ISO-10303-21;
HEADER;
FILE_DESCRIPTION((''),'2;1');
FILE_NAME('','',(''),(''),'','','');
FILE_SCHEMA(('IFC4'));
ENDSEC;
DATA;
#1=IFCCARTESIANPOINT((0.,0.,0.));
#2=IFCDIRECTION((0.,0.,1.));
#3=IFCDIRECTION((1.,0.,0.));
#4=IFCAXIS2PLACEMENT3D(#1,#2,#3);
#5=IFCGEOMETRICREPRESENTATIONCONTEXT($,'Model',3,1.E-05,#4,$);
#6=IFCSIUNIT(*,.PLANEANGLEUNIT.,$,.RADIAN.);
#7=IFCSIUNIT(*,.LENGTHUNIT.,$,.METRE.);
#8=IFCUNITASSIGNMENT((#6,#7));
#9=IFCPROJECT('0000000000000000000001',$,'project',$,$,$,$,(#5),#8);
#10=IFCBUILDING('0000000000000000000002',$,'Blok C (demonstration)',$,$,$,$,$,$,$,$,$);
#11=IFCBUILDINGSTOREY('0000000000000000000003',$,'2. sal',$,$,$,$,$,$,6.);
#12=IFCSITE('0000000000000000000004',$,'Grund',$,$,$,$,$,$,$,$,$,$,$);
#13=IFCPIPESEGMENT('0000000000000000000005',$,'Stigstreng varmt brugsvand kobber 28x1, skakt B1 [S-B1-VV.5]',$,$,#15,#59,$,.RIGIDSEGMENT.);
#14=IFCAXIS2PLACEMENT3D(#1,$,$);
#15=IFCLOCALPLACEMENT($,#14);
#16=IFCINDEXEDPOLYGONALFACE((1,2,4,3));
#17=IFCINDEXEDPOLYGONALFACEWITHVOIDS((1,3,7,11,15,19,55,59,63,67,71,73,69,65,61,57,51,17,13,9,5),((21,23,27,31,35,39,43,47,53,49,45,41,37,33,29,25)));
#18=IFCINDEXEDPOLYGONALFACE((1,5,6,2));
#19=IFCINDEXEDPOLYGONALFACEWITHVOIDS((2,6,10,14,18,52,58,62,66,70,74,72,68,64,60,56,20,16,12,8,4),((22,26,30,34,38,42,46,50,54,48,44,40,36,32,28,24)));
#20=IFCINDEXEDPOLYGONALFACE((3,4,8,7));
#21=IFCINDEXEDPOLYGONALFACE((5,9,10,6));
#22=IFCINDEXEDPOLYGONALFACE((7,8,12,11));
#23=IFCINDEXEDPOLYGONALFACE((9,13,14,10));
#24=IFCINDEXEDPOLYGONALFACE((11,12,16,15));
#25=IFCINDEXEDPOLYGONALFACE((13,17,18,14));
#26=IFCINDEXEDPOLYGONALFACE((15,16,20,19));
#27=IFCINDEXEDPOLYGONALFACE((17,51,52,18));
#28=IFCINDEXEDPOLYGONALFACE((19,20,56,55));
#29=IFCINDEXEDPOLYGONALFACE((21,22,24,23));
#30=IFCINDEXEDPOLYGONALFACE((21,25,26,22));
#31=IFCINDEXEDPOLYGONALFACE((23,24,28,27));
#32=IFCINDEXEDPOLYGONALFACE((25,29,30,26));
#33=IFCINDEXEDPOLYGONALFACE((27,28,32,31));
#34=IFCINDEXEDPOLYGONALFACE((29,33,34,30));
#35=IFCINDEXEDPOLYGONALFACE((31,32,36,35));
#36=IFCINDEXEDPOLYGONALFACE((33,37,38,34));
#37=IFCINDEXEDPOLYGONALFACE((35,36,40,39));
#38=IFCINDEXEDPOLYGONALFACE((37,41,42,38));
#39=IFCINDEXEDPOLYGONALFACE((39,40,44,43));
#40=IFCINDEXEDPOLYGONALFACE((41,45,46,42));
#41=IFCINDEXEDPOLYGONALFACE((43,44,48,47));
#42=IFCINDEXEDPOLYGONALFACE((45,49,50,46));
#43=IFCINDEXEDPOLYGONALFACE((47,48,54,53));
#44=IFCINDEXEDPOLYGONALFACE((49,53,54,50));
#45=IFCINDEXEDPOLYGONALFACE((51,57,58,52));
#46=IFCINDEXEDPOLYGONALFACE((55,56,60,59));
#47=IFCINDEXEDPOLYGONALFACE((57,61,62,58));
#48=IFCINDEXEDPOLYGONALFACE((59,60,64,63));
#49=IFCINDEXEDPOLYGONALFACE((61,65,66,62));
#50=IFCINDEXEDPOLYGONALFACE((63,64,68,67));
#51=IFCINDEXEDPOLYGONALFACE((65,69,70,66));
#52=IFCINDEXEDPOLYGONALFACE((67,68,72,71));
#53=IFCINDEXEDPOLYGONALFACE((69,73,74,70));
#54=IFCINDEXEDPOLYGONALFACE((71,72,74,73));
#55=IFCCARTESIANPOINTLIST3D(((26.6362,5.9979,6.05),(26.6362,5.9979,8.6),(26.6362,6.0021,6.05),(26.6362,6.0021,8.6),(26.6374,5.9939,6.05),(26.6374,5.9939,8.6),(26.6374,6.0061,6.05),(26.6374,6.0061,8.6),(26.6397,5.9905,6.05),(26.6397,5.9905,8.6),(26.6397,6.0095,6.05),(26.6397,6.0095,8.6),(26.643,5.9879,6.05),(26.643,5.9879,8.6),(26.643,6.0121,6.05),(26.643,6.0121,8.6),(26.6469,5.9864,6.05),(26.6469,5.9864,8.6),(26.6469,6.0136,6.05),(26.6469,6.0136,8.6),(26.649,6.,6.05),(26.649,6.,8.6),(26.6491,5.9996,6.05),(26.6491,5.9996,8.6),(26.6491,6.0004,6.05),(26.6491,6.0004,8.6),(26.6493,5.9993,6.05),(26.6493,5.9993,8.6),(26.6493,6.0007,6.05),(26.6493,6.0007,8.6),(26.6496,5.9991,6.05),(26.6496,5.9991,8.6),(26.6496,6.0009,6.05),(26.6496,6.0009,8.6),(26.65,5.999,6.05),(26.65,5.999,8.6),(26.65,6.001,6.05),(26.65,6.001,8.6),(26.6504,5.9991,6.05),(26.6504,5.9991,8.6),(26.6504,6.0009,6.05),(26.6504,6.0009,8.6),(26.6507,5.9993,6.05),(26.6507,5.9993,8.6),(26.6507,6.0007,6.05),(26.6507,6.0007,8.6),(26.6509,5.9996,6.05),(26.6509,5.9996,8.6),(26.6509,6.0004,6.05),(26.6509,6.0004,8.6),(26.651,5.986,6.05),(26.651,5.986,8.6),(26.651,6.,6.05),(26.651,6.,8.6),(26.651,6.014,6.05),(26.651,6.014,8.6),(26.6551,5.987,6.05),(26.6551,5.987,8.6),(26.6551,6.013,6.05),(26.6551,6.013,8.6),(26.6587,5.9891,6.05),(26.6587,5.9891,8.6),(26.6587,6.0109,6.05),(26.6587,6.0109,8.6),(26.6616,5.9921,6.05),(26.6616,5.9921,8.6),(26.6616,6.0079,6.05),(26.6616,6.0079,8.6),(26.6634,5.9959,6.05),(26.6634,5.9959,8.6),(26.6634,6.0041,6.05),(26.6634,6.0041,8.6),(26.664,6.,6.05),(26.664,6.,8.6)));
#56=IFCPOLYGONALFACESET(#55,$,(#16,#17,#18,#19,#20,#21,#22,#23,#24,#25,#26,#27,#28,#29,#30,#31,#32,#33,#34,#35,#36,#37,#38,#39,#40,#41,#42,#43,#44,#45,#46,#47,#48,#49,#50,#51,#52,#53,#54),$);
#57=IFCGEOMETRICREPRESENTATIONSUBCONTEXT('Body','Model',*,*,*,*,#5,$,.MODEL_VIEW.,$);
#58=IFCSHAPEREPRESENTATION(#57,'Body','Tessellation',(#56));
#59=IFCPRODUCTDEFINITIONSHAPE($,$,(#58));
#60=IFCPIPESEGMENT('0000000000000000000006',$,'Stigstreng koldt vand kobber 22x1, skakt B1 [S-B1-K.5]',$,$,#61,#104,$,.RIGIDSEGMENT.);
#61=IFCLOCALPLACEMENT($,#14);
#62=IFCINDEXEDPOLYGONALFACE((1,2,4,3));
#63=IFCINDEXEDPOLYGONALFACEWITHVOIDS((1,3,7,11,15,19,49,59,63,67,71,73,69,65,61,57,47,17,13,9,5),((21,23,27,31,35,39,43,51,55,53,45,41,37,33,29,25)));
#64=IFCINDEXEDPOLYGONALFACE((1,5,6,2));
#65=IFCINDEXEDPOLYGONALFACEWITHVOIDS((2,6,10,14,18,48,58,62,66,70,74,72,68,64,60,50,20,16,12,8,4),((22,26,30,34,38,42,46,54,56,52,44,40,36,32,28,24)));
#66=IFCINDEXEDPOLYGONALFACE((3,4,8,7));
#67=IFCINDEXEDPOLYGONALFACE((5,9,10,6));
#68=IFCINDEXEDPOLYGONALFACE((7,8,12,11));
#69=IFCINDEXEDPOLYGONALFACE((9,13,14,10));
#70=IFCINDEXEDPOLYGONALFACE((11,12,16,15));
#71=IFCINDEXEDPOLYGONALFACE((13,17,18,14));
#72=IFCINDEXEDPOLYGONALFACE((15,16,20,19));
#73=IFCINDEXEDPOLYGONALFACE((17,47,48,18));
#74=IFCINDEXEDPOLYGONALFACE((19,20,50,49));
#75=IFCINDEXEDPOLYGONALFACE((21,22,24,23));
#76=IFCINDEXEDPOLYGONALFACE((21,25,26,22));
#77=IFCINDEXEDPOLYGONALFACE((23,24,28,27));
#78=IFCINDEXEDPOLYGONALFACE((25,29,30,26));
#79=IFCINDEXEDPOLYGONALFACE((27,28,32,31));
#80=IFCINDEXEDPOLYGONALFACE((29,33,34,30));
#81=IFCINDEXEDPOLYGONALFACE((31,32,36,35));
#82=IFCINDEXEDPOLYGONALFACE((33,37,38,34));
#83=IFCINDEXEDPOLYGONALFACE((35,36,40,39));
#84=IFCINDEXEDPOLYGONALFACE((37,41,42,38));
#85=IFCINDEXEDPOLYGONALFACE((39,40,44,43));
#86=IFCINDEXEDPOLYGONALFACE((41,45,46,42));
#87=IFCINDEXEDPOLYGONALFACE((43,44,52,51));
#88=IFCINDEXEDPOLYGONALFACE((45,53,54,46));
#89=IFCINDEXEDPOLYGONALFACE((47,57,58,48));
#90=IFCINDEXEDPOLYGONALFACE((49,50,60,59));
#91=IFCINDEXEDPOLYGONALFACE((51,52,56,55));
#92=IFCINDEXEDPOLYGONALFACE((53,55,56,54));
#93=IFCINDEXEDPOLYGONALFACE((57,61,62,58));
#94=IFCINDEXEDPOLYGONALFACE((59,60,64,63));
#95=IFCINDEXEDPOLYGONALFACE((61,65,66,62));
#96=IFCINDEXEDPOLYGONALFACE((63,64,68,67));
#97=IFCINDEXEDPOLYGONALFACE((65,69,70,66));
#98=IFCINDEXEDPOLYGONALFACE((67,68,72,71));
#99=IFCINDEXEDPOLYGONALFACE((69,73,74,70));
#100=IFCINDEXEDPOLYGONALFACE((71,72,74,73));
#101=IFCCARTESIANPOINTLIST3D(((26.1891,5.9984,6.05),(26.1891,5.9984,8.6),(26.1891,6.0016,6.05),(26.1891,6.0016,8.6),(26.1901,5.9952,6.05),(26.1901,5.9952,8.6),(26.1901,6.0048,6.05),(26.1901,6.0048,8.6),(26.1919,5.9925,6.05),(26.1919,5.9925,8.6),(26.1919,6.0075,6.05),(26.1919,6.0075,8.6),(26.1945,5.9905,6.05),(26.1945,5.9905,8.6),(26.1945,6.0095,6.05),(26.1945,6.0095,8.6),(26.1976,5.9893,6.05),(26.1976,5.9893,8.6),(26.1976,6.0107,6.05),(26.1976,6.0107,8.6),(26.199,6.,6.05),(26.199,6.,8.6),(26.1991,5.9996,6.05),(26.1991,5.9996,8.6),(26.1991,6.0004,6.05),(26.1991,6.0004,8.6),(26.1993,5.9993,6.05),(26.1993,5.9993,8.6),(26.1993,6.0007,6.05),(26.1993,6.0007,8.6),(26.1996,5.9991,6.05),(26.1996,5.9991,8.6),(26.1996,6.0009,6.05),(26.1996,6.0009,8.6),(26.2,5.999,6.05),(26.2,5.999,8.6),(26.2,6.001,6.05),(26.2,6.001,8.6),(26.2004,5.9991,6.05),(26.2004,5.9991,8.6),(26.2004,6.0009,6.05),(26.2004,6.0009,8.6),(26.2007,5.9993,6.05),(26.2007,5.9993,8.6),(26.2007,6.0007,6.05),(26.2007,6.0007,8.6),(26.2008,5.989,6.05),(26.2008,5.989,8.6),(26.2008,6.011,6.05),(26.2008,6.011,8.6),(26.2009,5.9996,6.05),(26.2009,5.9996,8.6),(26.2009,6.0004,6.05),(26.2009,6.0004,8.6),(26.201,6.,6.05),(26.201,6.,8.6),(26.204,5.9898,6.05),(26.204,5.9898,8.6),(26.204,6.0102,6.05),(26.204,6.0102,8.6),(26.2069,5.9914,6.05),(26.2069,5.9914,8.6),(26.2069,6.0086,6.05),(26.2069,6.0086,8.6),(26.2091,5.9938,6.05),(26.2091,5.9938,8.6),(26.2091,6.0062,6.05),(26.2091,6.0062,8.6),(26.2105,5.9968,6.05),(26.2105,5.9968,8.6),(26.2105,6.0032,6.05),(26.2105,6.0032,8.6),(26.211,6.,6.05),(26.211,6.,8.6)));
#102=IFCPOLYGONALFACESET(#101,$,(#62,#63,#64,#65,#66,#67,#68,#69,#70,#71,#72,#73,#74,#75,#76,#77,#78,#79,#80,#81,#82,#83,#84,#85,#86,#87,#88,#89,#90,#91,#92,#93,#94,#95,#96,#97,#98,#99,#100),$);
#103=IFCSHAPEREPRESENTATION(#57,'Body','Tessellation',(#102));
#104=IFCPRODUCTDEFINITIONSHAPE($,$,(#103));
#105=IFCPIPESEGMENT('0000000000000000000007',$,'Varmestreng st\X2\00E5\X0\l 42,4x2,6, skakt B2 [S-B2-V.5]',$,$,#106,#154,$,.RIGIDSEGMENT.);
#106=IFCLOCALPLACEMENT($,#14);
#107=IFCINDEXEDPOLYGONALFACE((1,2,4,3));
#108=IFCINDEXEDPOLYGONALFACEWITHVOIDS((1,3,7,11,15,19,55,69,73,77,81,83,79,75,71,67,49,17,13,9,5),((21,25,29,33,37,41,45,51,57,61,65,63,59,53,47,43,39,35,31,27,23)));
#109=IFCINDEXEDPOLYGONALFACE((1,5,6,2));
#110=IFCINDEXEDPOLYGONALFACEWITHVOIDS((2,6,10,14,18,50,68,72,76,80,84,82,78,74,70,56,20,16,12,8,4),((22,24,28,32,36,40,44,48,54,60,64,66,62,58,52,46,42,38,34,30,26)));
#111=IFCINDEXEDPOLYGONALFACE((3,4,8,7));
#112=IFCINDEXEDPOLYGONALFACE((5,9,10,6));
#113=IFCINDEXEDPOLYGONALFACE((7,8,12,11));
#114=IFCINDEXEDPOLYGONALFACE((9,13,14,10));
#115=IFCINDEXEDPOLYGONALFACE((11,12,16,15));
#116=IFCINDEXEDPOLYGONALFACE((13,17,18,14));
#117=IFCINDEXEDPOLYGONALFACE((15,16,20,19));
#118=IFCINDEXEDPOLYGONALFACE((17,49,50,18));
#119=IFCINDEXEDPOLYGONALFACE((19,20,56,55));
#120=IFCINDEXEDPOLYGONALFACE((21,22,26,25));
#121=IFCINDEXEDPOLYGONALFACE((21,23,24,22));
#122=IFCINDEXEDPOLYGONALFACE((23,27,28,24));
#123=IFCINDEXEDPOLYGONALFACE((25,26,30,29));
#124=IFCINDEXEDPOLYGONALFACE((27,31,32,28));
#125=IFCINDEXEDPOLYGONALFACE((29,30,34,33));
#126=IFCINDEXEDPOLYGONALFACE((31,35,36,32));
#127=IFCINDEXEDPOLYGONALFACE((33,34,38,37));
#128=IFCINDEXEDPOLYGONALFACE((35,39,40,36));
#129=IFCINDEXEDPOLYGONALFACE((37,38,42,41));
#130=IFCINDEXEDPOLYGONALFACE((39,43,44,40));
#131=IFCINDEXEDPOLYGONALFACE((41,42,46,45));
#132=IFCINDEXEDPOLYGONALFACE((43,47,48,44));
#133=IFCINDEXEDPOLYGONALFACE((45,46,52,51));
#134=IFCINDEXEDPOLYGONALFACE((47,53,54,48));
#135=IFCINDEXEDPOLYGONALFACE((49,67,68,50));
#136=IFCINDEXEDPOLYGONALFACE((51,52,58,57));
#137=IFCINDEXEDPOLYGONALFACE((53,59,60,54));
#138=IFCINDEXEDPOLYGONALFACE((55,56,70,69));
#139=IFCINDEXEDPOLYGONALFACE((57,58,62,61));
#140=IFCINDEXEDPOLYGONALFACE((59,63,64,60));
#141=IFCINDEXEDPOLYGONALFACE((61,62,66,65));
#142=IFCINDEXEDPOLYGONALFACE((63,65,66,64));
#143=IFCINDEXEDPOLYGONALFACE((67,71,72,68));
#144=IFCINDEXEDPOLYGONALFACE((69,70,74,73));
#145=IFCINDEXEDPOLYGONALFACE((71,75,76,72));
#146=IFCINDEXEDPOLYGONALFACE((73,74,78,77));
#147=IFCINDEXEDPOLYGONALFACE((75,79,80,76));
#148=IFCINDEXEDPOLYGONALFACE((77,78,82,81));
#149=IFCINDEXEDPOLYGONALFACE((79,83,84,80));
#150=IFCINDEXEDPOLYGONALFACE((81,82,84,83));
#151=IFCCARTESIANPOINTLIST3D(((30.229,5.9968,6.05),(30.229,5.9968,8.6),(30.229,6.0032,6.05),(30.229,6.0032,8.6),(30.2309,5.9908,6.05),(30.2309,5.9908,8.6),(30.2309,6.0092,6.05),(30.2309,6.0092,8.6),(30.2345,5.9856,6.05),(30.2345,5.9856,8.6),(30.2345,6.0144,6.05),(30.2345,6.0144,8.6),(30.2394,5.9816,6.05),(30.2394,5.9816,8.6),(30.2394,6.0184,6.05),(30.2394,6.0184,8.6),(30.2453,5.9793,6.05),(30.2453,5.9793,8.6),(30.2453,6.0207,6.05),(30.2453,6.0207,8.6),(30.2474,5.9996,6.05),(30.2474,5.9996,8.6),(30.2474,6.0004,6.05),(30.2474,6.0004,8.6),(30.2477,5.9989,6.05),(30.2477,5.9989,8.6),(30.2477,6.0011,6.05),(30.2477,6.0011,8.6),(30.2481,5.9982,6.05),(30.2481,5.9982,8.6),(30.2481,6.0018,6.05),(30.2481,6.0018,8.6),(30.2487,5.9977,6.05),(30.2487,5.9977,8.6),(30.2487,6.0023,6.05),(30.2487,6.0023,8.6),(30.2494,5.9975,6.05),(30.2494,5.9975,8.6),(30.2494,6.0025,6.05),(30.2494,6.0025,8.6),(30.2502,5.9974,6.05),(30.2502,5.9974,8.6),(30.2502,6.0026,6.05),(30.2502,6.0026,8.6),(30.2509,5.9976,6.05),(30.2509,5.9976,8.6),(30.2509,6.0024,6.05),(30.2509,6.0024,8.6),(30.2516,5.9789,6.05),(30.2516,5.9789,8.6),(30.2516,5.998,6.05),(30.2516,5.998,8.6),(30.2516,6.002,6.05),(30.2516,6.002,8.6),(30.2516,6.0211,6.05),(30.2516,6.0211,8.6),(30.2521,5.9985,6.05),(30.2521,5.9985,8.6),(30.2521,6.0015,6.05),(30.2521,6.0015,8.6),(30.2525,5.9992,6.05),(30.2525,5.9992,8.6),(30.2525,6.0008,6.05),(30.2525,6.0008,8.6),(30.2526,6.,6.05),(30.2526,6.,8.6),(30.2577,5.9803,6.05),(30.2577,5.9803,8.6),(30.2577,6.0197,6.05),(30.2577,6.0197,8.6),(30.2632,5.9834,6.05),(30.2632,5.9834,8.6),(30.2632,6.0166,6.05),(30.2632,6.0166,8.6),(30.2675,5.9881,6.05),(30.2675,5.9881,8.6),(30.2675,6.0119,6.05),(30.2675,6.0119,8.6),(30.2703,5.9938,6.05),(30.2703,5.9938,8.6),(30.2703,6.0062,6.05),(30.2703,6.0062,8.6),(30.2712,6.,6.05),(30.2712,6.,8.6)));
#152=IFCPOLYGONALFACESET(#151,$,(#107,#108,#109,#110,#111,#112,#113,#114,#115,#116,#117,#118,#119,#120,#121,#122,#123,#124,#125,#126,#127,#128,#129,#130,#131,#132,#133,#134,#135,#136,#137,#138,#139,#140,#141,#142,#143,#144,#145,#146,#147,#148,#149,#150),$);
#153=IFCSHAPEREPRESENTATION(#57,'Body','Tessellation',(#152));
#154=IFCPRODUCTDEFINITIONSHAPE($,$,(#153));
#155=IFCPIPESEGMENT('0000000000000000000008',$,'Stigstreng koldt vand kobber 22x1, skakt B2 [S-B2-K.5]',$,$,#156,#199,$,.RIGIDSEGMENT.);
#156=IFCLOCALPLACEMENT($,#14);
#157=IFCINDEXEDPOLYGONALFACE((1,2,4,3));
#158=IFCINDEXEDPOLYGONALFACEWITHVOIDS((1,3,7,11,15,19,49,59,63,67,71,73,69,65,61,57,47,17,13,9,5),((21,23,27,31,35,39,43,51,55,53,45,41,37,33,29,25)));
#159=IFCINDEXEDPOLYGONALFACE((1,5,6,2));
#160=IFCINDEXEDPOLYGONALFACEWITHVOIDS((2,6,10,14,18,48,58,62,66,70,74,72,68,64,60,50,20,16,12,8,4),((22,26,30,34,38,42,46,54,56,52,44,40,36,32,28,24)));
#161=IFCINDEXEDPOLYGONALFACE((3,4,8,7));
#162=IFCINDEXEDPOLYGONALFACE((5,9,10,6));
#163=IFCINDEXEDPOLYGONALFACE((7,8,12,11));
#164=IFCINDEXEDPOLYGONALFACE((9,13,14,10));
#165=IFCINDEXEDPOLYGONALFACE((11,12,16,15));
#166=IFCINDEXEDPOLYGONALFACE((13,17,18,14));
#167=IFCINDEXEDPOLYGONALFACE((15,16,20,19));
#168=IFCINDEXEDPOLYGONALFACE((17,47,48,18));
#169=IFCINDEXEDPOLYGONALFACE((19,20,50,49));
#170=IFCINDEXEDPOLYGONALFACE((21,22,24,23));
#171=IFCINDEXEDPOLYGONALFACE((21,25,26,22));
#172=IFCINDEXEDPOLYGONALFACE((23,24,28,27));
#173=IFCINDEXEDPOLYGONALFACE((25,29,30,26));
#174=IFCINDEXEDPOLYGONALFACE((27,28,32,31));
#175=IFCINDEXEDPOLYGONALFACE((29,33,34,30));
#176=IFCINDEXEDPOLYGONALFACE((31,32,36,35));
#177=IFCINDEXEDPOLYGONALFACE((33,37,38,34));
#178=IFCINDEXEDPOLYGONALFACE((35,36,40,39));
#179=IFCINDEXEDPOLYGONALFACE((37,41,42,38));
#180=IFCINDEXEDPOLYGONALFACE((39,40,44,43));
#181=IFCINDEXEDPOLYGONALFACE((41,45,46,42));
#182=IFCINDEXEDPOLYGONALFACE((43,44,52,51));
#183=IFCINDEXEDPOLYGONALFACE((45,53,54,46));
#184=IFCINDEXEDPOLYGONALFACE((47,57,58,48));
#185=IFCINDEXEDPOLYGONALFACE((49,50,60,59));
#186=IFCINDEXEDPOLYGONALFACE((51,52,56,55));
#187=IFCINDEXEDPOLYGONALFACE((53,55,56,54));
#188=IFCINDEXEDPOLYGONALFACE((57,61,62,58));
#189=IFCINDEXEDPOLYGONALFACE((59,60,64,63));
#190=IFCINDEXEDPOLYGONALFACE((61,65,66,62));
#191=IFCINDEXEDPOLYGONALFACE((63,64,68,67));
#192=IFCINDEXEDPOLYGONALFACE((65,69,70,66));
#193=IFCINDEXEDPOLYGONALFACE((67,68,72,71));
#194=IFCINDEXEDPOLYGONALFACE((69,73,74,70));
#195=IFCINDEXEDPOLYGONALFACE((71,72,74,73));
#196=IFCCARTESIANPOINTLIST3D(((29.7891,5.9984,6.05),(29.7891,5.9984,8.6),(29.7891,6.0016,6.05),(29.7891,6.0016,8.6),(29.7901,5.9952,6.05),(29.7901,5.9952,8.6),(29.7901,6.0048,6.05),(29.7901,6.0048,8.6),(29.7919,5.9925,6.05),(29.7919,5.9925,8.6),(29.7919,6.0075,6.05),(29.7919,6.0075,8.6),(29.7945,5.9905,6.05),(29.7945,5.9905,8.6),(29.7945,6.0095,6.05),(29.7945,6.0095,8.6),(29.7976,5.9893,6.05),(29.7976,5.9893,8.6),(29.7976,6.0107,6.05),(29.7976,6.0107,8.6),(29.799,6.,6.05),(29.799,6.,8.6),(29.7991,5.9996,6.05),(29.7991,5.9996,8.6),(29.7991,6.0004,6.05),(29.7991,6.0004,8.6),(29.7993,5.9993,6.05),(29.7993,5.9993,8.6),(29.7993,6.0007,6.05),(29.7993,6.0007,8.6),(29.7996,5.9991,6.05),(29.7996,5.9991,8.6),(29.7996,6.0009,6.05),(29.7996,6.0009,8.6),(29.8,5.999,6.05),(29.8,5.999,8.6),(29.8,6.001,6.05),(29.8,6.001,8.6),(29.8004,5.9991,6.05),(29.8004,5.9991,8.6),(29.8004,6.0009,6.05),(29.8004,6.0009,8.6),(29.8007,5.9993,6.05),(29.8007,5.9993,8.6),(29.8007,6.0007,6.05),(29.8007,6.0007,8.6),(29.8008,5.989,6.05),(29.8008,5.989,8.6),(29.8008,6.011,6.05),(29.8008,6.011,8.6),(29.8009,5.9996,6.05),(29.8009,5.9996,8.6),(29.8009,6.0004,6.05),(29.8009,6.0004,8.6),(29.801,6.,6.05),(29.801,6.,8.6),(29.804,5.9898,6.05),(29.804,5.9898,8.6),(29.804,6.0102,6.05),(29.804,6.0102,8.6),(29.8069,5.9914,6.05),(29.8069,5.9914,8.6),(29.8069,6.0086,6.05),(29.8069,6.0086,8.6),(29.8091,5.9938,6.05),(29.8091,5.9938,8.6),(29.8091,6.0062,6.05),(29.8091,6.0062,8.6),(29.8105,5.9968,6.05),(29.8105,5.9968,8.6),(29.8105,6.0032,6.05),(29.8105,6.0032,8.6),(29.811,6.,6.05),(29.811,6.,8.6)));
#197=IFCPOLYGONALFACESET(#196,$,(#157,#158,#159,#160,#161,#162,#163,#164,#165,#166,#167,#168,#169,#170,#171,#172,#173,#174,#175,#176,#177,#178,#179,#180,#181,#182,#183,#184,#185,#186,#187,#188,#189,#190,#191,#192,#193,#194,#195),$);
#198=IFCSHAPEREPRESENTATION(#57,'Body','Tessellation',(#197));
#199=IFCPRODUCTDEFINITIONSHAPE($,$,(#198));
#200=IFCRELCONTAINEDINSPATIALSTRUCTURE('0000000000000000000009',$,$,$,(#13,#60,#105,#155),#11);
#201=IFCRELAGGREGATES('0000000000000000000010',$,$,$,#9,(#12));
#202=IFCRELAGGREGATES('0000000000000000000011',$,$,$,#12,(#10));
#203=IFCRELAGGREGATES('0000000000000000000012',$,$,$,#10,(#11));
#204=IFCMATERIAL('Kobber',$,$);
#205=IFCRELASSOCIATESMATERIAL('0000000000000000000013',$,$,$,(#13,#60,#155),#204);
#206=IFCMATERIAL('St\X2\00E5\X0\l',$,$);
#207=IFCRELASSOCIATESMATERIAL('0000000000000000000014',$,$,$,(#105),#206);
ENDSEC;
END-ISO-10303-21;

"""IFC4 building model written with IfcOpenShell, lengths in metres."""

from ifc_helpers import new_model, si_unit, frame, origin_with_axes, place, context, subcontext, project, spatial, hollow_circle, extrude, material, element, save


model = new_model("IFC4")

# Units and contexts
model_context = context("Model", 3, precision=1e-05, world=origin_with_axes())
body_context = subcontext(model_context, "Body", "Model", "MODEL_VIEW")
ifc_project = project(units=[si_unit("PLANEANGLEUNIT", "RADIAN"), si_unit("LENGTHUNIT", "METRE")], contexts=[model_context])

# Site, building, storey
site = spatial("IfcSite", under=ifc_project, Name="Grund")
building = spatial("IfcBuilding", under=site, Name="Blok C (demonstration)")
storey = spatial("IfcBuildingStorey", under=building, Name="2. sal", Elevation=6.0)

# Pipe segments
ifc_material_1 = material(Name="Stål")
ifc_material_2 = material(Name="Kobber")
pipe_segment_1_placement = place(None, origin_with_axes())
element("IfcPipeSegment", 1, at=pipe_segment_1_placement, inside=storey, material=ifc_material_2, Name="Stigstreng varmt brugsvand kobber 28x1, skakt B1 [S-B1-VV.5]", PredefinedType="RIGIDSEGMENT", context=body_context, shape_type="SweptSolid", body=[
    extrude(hollow_circle(Radius=0.014, WallThickness=0.013), frame((26.65, 6.0, 6.05), z_axis=(0.0, 0.0, 1.0), x_axis=(1.0, 0.0, 0.0)), (0.0, 0.0, 1.0), 2.55),
])
pipe_segment_2_placement = place(None, origin_with_axes())
element("IfcPipeSegment", 2, at=pipe_segment_2_placement, inside=storey, material=ifc_material_2, Name="Stigstreng koldt vand kobber 22x1, skakt B1 [S-B1-K.5]", PredefinedType="RIGIDSEGMENT", context=body_context, shape_type="SweptSolid", body=[
    extrude(hollow_circle(Radius=0.011, WallThickness=0.01), frame((26.2, 6.0, 6.05), z_axis=(0.0, 0.0, 1.0), x_axis=(1.0, 0.0, 0.0)), (0.0, 0.0, 1.0), 2.55),
])
pipe_segment_3_placement = place(None, origin_with_axes())
element("IfcPipeSegment", 3, at=pipe_segment_3_placement, inside=storey, material=ifc_material_1, Name="Varmestreng stål 42,4x2,6, skakt B2 [S-B2-V.5]", PredefinedType="RIGIDSEGMENT", context=body_context, shape_type="SweptSolid", body=[
    extrude(hollow_circle(Radius=0.0212, WallThickness=0.0186), frame((30.25, 6.0, 6.05), z_axis=(0.0, 0.0, 1.0), x_axis=(1.0, 0.0, 0.0)), (0.0, 0.0, 1.0), 2.55),
])
pipe_segment_4_placement = place(None, origin_with_axes())
element("IfcPipeSegment", 4, at=pipe_segment_4_placement, inside=storey, material=ifc_material_2, Name="Stigstreng koldt vand kobber 22x1, skakt B2 [S-B2-K.5]", PredefinedType="RIGIDSEGMENT", context=body_context, shape_type="SweptSolid", body=[
    extrude(hollow_circle(Radius=0.011, WallThickness=0.01), frame((29.8, 6.0, 6.05), z_axis=(0.0, 0.0, 1.0), x_axis=(1.0, 0.0, 0.0)), (0.0, 0.0, 1.0), 2.55),
])

save(model, "model.ifc")
